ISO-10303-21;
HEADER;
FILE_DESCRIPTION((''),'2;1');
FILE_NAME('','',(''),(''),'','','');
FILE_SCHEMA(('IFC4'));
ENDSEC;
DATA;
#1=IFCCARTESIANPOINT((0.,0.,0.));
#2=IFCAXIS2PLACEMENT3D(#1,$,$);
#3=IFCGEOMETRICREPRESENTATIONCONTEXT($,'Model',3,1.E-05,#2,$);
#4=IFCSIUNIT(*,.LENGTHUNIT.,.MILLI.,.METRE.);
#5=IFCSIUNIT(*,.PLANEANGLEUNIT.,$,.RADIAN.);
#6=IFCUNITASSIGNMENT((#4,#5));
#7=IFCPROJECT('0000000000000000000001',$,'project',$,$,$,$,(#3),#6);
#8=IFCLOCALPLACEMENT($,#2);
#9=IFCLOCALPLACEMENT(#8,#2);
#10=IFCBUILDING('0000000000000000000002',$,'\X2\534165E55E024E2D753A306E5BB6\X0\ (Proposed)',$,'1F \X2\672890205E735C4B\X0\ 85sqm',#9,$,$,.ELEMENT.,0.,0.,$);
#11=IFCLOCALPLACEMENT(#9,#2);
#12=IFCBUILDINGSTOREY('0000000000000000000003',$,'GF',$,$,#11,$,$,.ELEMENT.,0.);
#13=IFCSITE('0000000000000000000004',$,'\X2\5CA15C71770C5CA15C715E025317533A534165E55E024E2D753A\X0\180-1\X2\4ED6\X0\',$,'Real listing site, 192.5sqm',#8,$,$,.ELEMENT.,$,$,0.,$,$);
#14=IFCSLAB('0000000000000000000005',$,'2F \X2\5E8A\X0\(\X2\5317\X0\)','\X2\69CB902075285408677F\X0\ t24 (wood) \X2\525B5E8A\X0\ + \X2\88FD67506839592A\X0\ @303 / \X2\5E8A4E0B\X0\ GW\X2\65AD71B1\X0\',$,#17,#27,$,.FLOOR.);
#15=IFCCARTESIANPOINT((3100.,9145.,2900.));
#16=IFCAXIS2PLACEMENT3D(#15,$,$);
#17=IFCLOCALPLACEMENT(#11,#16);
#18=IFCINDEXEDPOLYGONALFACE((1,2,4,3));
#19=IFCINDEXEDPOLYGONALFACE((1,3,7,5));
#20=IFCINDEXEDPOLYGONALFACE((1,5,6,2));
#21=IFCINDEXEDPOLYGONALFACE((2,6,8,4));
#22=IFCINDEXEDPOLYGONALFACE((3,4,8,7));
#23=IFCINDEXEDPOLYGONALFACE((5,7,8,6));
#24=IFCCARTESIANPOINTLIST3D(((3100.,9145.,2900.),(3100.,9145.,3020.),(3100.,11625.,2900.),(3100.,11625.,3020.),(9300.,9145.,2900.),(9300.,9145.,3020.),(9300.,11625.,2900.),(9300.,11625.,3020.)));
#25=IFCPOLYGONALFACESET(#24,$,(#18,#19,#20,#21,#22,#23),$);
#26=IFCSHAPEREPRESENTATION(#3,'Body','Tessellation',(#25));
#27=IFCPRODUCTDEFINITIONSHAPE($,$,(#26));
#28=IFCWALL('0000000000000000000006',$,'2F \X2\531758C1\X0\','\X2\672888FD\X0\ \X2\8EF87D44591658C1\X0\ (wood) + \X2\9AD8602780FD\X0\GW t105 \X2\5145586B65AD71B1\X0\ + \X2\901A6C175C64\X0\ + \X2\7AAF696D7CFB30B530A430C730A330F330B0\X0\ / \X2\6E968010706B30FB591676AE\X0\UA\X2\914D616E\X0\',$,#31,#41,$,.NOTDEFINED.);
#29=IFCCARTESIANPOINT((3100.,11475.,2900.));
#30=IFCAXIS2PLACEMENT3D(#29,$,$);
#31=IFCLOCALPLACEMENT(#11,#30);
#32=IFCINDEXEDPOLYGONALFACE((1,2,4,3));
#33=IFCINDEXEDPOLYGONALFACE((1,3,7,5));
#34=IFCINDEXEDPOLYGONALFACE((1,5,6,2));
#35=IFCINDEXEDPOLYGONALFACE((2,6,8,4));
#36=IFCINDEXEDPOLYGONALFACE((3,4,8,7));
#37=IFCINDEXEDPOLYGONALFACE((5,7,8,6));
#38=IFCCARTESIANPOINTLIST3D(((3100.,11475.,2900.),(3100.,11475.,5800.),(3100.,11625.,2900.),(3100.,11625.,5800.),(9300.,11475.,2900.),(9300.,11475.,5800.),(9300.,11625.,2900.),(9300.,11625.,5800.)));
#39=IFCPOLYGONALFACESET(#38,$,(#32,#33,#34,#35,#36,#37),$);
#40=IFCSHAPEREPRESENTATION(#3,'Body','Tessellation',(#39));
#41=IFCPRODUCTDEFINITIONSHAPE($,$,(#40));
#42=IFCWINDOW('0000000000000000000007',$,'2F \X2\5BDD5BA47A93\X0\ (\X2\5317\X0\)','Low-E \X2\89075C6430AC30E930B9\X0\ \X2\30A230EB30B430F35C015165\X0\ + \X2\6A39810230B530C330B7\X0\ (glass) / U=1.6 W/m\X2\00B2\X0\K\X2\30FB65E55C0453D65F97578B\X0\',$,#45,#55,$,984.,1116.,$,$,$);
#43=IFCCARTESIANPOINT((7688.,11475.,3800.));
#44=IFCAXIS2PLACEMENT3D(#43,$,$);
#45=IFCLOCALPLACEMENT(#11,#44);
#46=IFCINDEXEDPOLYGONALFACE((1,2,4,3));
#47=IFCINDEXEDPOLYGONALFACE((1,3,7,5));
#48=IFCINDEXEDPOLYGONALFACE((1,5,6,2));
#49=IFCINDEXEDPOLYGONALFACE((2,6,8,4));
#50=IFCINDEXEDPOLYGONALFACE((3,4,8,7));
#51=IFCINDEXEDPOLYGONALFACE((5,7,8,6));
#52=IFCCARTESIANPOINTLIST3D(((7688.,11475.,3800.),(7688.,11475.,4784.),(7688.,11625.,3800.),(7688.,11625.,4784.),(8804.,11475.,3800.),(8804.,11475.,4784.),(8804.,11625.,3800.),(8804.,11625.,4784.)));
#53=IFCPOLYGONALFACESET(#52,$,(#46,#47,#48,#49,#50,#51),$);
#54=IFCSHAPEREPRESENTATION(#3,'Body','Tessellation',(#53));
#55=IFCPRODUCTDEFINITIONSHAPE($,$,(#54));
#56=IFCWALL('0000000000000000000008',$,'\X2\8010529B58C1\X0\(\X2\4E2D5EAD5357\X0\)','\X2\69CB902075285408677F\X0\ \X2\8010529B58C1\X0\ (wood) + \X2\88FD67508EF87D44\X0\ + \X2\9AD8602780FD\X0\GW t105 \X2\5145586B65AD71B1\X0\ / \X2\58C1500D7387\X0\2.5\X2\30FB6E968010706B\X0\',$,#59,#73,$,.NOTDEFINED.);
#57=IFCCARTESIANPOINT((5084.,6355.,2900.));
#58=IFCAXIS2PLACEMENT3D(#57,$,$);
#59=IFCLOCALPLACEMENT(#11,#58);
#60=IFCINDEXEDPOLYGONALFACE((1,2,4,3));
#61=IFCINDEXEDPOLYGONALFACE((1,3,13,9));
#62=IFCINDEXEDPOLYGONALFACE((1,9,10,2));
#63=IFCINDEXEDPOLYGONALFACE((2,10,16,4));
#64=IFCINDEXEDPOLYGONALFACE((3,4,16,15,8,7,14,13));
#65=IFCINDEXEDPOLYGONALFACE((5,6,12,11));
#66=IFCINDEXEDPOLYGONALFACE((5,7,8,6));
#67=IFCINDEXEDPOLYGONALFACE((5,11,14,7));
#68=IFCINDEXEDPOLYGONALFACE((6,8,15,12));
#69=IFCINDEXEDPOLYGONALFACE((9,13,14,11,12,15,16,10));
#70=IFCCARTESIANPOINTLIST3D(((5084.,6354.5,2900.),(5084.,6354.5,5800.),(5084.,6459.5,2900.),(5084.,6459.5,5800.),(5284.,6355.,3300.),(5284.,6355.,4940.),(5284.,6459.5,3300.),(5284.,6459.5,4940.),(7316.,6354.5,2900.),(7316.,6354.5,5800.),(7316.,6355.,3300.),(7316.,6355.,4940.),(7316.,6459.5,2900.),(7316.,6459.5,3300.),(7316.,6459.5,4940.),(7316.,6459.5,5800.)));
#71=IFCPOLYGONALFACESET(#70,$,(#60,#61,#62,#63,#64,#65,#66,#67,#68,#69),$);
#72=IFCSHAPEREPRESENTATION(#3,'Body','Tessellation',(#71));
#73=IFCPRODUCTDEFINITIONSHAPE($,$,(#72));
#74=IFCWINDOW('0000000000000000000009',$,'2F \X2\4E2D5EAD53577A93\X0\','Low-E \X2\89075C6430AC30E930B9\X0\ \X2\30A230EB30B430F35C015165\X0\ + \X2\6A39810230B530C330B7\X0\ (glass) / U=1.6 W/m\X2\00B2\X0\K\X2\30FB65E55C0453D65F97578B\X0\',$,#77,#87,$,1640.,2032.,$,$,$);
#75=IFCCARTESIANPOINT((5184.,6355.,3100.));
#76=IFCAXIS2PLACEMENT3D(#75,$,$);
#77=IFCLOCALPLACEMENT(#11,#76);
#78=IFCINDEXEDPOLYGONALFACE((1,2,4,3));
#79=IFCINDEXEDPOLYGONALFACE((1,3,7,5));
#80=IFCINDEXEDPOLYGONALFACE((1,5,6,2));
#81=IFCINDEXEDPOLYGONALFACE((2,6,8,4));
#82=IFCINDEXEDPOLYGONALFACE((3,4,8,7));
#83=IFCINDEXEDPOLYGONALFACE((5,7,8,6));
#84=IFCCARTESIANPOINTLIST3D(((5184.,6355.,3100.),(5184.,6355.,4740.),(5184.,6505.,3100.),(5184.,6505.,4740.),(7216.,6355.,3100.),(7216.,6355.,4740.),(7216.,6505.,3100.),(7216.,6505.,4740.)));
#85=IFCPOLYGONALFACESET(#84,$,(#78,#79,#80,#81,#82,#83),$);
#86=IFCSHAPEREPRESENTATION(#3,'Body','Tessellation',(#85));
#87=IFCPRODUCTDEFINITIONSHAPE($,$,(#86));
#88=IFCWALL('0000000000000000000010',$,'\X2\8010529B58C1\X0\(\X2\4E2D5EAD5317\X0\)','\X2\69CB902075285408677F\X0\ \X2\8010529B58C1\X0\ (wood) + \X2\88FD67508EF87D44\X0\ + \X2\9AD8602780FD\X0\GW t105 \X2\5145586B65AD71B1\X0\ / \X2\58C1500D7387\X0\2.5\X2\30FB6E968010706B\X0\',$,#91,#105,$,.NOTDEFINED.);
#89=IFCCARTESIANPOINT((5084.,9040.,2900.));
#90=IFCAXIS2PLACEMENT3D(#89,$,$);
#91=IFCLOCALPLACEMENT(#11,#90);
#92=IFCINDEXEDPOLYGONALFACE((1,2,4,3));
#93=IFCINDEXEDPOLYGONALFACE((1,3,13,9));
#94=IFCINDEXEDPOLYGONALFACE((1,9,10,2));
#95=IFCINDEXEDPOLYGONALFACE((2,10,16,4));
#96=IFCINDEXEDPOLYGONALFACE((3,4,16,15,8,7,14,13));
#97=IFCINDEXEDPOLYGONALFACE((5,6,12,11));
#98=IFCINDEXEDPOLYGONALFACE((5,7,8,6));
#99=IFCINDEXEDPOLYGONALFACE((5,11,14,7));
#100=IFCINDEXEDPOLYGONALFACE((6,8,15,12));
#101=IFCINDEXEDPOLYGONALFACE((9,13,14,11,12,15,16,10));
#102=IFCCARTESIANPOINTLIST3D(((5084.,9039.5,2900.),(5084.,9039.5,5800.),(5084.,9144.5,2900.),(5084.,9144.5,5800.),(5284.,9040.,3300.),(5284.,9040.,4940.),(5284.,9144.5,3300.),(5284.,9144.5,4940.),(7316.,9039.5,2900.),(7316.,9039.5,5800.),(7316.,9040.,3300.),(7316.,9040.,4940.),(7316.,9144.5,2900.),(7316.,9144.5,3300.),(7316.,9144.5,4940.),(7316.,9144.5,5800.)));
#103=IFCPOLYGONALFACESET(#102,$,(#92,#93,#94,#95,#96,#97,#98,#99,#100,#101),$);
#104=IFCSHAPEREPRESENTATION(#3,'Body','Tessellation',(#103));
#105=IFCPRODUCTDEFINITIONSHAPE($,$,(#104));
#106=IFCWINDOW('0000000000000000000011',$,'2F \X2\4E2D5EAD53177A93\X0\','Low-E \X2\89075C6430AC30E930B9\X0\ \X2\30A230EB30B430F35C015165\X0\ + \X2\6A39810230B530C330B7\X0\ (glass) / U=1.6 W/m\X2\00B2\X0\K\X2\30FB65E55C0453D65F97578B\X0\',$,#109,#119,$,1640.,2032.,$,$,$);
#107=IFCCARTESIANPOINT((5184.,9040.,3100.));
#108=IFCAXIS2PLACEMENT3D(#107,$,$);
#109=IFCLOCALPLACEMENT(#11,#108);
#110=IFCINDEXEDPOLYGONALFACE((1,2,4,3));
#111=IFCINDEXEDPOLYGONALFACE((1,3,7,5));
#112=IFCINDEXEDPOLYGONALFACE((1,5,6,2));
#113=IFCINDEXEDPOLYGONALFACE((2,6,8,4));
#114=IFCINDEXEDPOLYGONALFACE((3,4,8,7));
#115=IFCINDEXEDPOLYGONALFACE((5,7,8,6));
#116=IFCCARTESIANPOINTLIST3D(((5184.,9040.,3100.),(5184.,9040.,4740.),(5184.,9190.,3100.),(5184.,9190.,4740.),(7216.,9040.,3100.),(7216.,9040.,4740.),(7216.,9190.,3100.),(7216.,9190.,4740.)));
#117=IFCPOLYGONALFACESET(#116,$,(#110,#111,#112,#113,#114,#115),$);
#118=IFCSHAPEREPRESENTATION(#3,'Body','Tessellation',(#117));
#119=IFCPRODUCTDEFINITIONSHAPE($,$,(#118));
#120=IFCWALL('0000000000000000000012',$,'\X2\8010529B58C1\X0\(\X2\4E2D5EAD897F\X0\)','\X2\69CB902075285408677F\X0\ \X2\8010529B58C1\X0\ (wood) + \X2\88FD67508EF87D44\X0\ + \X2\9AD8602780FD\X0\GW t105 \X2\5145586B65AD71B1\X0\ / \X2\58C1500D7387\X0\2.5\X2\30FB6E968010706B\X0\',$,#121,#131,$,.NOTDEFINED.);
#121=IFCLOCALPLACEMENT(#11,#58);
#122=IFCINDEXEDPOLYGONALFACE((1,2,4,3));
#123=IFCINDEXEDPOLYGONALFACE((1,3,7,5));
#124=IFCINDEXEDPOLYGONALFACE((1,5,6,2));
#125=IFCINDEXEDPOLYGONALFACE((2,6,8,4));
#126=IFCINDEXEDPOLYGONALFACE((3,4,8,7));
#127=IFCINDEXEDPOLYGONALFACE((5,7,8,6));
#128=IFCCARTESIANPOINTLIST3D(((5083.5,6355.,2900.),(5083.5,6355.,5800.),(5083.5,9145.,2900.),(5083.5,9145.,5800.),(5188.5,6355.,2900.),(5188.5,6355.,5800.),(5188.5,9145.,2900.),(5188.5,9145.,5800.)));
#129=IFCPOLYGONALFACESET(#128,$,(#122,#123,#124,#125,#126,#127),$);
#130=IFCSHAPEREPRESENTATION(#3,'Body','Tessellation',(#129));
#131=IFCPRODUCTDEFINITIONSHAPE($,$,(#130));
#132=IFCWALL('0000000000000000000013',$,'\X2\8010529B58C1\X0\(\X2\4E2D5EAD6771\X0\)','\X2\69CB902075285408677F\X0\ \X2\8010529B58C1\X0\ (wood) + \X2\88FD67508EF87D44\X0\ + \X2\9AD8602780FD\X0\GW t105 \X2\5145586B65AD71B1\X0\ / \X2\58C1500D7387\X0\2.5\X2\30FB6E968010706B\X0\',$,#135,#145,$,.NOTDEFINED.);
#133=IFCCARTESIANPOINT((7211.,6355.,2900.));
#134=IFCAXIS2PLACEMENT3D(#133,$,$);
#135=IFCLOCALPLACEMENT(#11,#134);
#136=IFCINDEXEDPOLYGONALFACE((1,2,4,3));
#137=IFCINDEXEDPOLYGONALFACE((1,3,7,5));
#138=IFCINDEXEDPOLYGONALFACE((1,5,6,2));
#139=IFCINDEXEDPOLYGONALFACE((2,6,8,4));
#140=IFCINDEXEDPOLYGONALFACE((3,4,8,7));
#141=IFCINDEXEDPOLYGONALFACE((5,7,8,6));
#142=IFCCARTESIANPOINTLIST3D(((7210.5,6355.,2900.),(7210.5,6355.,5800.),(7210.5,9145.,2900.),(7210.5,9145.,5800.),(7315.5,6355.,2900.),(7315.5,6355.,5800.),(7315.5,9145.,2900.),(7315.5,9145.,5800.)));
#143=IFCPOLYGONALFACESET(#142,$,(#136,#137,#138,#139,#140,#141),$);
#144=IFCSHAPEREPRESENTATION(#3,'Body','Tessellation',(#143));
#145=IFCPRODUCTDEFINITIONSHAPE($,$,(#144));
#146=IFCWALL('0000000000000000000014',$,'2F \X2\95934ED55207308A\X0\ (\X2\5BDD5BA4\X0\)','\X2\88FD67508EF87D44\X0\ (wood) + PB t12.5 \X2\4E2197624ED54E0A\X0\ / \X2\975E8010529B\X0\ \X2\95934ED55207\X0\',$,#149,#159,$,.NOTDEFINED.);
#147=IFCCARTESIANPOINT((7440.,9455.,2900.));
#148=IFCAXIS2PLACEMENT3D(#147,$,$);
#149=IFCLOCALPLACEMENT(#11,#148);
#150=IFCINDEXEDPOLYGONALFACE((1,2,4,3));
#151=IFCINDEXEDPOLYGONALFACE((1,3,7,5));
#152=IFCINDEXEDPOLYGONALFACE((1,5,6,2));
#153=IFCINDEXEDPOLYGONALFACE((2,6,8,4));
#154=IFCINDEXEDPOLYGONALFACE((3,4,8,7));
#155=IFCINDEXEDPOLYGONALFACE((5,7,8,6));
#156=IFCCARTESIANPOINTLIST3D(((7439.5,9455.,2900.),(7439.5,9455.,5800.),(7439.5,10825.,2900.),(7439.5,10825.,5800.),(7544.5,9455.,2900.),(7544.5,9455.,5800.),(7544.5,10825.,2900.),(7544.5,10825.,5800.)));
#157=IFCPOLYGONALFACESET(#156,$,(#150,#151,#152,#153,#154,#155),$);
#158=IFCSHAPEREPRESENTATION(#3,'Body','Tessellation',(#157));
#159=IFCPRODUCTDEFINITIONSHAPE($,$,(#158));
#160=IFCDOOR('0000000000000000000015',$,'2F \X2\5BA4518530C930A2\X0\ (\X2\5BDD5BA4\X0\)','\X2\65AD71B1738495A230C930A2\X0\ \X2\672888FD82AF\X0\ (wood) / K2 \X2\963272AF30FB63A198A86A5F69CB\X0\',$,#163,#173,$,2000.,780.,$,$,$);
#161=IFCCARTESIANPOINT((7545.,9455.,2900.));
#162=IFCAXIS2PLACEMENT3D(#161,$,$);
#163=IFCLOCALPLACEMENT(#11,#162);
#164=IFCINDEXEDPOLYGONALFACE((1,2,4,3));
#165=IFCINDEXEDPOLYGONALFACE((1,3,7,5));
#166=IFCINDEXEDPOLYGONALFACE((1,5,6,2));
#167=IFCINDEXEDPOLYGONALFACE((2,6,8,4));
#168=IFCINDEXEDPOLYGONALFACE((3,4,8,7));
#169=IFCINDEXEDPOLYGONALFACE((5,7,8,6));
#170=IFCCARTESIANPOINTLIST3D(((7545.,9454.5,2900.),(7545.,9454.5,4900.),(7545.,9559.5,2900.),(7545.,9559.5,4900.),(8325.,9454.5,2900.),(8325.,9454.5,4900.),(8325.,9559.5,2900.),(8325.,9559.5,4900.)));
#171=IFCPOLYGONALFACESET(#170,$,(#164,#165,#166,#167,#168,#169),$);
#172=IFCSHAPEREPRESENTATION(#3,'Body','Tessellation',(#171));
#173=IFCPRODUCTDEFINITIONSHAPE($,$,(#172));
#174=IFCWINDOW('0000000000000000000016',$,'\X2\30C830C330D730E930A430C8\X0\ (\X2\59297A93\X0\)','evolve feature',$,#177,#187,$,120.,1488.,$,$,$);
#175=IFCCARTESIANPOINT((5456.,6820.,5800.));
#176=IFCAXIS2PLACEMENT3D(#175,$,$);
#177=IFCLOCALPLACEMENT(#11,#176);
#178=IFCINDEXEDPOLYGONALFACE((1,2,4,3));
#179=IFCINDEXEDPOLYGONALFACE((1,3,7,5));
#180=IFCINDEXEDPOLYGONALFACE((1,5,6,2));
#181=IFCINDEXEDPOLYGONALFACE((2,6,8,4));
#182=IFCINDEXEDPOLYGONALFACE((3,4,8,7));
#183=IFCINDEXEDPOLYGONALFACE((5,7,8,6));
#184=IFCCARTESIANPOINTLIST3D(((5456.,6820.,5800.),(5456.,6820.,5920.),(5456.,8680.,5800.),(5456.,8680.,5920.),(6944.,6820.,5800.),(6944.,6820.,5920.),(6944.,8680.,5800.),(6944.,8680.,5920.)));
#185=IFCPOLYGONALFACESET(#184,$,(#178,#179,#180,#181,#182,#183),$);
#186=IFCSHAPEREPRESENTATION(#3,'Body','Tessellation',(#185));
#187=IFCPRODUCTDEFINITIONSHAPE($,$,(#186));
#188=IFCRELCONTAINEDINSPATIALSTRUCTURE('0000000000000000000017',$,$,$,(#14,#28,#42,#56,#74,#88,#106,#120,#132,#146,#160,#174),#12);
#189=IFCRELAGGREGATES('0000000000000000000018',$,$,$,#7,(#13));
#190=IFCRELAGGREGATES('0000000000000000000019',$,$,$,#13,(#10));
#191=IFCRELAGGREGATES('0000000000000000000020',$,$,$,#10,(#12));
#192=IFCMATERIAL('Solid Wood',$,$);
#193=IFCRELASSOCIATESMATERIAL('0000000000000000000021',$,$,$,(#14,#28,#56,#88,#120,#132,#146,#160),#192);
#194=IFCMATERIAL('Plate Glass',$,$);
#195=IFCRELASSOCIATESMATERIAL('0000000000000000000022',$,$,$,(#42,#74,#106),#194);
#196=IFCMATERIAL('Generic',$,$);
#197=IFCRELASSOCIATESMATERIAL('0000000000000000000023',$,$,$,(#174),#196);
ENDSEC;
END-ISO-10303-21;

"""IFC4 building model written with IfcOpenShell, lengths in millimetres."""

from ifc_helpers import new_model, si_unit, frame, frame_2d, origin, place, context, project, spatial, rectangle, extrude, material, element, fill, save


model = new_model("IFC4")

# Units and contexts
model_context = context("Model", 3, precision=1e-05, world=origin())
ifc_project = project(units=[si_unit("LENGTHUNIT", "METRE", prefix="MILLI"), si_unit("PLANEANGLEUNIT", "RADIAN")], contexts=[model_context])

# Site, building, storey
site_placement = place(None, origin())
site = spatial("IfcSite", under=ifc_project, at=site_placement, Name="岡山県岡山市北区十日市中町180-1他", ObjectType="Real listing site, 192.5sqm", CompositionType="ELEMENT", RefElevation=0.0)
building_placement = place(site_placement, origin())
building = spatial("IfcBuilding", under=site, at=building_placement, Name="十日市中町の家 (Proposed)", ObjectType="1F 木造平屋 85sqm", CompositionType="ELEMENT", ElevationOfRefHeight=0.0, ElevationOfTerrain=0.0)
storey_placement = place(building_placement, origin())
storey = spatial("IfcBuildingStorey", under=building, at=storey_placement, Name="GF", CompositionType="ELEMENT", Elevation=0.0)

# Slab
ifc_material_1 = material(Name="Solid Wood")
slab_placement = place(storey_placement, frame((3100.0, 9145.0, 2900.0)))
element("IfcSlab", 1, at=slab_placement, inside=storey, material=ifc_material_1, Name="2F 床(北)", Description="構造用合板 t24 (wood) 剛床 + 製材根太 @303 / 床下 GW断熱", PredefinedType="FLOOR", context=model_context, shape_type="SweptSolid", body=[
    extrude(rectangle(XDim=6200.0, YDim=2480.0, at=frame_2d((3100.0, 1240.0))), frame((3100.0, 9145.0, 2900.0)), (0.0, 0.0, 1.0), 120.0),
])

# Walls, openings, windows
wall_1_placement = place(storey_placement, frame((3100.0, 11475.0, 2900.0)))
wall_1 = element("IfcWall", 2, at=wall_1_placement, inside=storey, material=ifc_material_1, Name="2F 北壁", Description="木製 軸組外壁 (wood) + 高性能GW t105 充填断熱 + 通気層 + 窯業系サイディング / 準耐火・外皮UA配慮", PredefinedType="NOTDEFINED", context=model_context, shape_type="SweptSolid", body=[
    extrude(rectangle(XDim=6200.0, YDim=150.0, at=frame_2d((3100.0, 75.0))), frame((3100.0, 11475.0, 2900.0)), (0.0, 0.0, 1.0), 2900.0),
])
opening_1_placement = place(storey_placement, frame((7688.0, 11475.0, 3800.0)))
opening_1 = element("IfcOpeningElement", 3, at=opening_1_placement, cuts=wall_1, PredefinedType="NOTDEFINED", context=model_context, shape_type="SweptSolid", body=[
    extrude(rectangle(XDim=1116.0, YDim=150.0, at=frame_2d((558.0, 75.0))), frame((7688.0, 11475.0, 3800.0)), (0.0, 0.0, 1.0), 984.0),
])
ifc_material_2 = material(Name="Plate Glass")
window_1_placement = place(storey_placement, frame((7688.0, 11475.0, 3800.0)))
window_1 = element("IfcWindow", 4, at=window_1_placement, inside=storey, material=ifc_material_2, Name="2F 寝室窓 (北)", Description="Low-E 複層ガラス アルゴン封入 + 樹脂サッシ (glass) / U=1.6 W/m²K・日射取得型", OverallHeight=984.0, OverallWidth=1116.0, context=model_context, shape_type="SweptSolid", body=[
    extrude(rectangle(XDim=1116.0, YDim=150.0, at=frame_2d((558.0, 75.0))), frame((7688.0, 11475.0, 3800.0)), (0.0, 0.0, 1.0), 984.0),
])
fill(opening_1, window_1)
wall_2_placement = place(storey_placement, frame((5084.0, 6355.0, 2900.0)))
wall_2 = element("IfcWall", 5, at=wall_2_placement, inside=storey, material=ifc_material_1, Name="耐力壁(中庭南)", Description="構造用合板 耐力壁 (wood) + 製材軸組 + 高性能GW t105 充填断熱 / 壁倍率2.5・準耐火", PredefinedType="NOTDEFINED", context=model_context, shape_type="SweptSolid", body=[
    extrude(rectangle(XDim=2232.0, YDim=105.0, at=frame_2d((1116.0, 52.0))), frame((5084.0, 6355.0, 2900.0)), (0.0, 0.0, 1.0), 2900.0),
])
opening_2_placement = place(storey_placement, frame((5184.0, 6355.0, 3100.0)))
opening_2 = element("IfcOpeningElement", 6, at=opening_2_placement, cuts=wall_2, PredefinedType="NOTDEFINED", context=model_context, shape_type="SweptSolid", body=[
    extrude(rectangle(XDim=2032.0, YDim=150.0, at=frame_2d((1016.0, 75.0))), frame((5184.0, 6355.0, 3100.0)), (0.0, 0.0, 1.0), 1640.0),
])
window_2_placement = place(storey_placement, frame((5184.0, 6355.0, 3100.0)))
window_2 = element("IfcWindow", 7, at=window_2_placement, inside=storey, material=ifc_material_2, Name="2F 中庭南窓", Description="Low-E 複層ガラス アルゴン封入 + 樹脂サッシ (glass) / U=1.6 W/m²K・日射取得型", OverallHeight=1640.0, OverallWidth=2032.0, context=model_context, shape_type="SweptSolid", body=[
    extrude(rectangle(XDim=2032.0, YDim=150.0, at=frame_2d((1016.0, 75.0))), frame((5184.0, 6355.0, 3100.0)), (0.0, 0.0, 1.0), 1640.0),
])
fill(opening_2, window_2)
wall_3_placement = place(storey_placement, frame((5084.0, 9040.0, 2900.0)))
wall_3 = element("IfcWall", 8, at=wall_3_placement, inside=storey, material=ifc_material_1, Name="耐力壁(中庭北)", Description="構造用合板 耐力壁 (wood) + 製材軸組 + 高性能GW t105 充填断熱 / 壁倍率2.5・準耐火", PredefinedType="NOTDEFINED", context=model_context, shape_type="SweptSolid", body=[
    extrude(rectangle(XDim=2232.0, YDim=105.0, at=frame_2d((1116.0, 52.0))), frame((5084.0, 9040.0, 2900.0)), (0.0, 0.0, 1.0), 2900.0),
])
opening_3_placement = place(storey_placement, frame((5184.0, 9040.0, 3100.0)))
opening_3 = element("IfcOpeningElement", 9, at=opening_3_placement, cuts=wall_3, PredefinedType="NOTDEFINED", context=model_context, shape_type="SweptSolid", body=[
    extrude(rectangle(XDim=2032.0, YDim=150.0, at=frame_2d((1016.0, 75.0))), frame((5184.0, 9040.0, 3100.0)), (0.0, 0.0, 1.0), 1640.0),
])
window_3_placement = place(storey_placement, frame((5184.0, 9040.0, 3100.0)))
window_3 = element("IfcWindow", 10, at=window_3_placement, inside=storey, material=ifc_material_2, Name="2F 中庭北窓", Description="Low-E 複層ガラス アルゴン封入 + 樹脂サッシ (glass) / U=1.6 W/m²K・日射取得型", OverallHeight=1640.0, OverallWidth=2032.0, context=model_context, shape_type="SweptSolid", body=[
    extrude(rectangle(XDim=2032.0, YDim=150.0, at=frame_2d((1016.0, 75.0))), frame((5184.0, 9040.0, 3100.0)), (0.0, 0.0, 1.0), 1640.0),
])
fill(opening_3, window_3)

# Walls
wall_4_placement = place(storey_placement, frame((5084.0, 6355.0, 2900.0)))
element("IfcWall", 11, at=wall_4_placement, inside=storey, material=ifc_material_1, Name="耐力壁(中庭西)", Description="構造用合板 耐力壁 (wood) + 製材軸組 + 高性能GW t105 充填断熱 / 壁倍率2.5・準耐火", PredefinedType="NOTDEFINED", context=model_context, shape_type="SweptSolid", body=[
    extrude(rectangle(XDim=105.0, YDim=2790.0, at=frame_2d((52.0, 1395.0))), frame((5084.0, 6355.0, 2900.0)), (0.0, 0.0, 1.0), 2900.0),
])
wall_5_placement = place(storey_placement, frame((7211.0, 6355.0, 2900.0)))
element("IfcWall", 12, at=wall_5_placement, inside=storey, material=ifc_material_1, Name="耐力壁(中庭東)", Description="構造用合板 耐力壁 (wood) + 製材軸組 + 高性能GW t105 充填断熱 / 壁倍率2.5・準耐火", PredefinedType="NOTDEFINED", context=model_context, shape_type="SweptSolid", body=[
    extrude(rectangle(XDim=105.0, YDim=2790.0, at=frame_2d((52.0, 1395.0))), frame((7211.0, 6355.0, 2900.0)), (0.0, 0.0, 1.0), 2900.0),
])
wall_6_placement = place(storey_placement, frame((7440.0, 9455.0, 2900.0)))
element("IfcWall", 13, at=wall_6_placement, inside=storey, material=ifc_material_1, Name="2F 間仕切り (寝室)", Description="製材軸組 (wood) + PB t12.5 両面仕上 / 非耐力 間仕切", PredefinedType="NOTDEFINED", context=model_context, shape_type="SweptSolid", body=[
    extrude(rectangle(XDim=105.0, YDim=1370.0, at=frame_2d((52.0, 685.0))), frame((7440.0, 9455.0, 2900.0)), (0.0, 0.0, 1.0), 2900.0),
])

# Door
door_placement = place(storey_placement, frame((7545.0, 9455.0, 2900.0)))
element("IfcDoor", 14, at=door_placement, inside=storey, material=ifc_material_1, Name="2F 室内ドア (寝室)", Description="断熱玄関ドア 木製芯 (wood) / K2 防犯・採風機構", OverallHeight=2000.0, OverallWidth=780.0, context=model_context, shape_type="SweptSolid", body=[
    extrude(rectangle(XDim=780.0, YDim=105.0, at=frame_2d((390.0, 52.0))), frame((7545.0, 9455.0, 2900.0)), (0.0, 0.0, 1.0), 2000.0),
])

# Window
ifc_material_3 = material(Name="Generic")
window_4_placement = place(storey_placement, frame((5456.0, 6820.0, 5800.0)))
element("IfcWindow", 15, at=window_4_placement, inside=storey, material=ifc_material_3, Name="トップライト (天窓)", Description="evolve feature", OverallHeight=120.0, OverallWidth=1488.0, context=model_context, shape_type="SweptSolid", body=[
    extrude(rectangle(XDim=1488.0, YDim=1860.0, at=frame_2d((744.0, 930.0))), frame((5456.0, 6820.0, 5800.0)), (0.0, 0.0, 1.0), 120.0),
])

save(model, "model.ifc")
